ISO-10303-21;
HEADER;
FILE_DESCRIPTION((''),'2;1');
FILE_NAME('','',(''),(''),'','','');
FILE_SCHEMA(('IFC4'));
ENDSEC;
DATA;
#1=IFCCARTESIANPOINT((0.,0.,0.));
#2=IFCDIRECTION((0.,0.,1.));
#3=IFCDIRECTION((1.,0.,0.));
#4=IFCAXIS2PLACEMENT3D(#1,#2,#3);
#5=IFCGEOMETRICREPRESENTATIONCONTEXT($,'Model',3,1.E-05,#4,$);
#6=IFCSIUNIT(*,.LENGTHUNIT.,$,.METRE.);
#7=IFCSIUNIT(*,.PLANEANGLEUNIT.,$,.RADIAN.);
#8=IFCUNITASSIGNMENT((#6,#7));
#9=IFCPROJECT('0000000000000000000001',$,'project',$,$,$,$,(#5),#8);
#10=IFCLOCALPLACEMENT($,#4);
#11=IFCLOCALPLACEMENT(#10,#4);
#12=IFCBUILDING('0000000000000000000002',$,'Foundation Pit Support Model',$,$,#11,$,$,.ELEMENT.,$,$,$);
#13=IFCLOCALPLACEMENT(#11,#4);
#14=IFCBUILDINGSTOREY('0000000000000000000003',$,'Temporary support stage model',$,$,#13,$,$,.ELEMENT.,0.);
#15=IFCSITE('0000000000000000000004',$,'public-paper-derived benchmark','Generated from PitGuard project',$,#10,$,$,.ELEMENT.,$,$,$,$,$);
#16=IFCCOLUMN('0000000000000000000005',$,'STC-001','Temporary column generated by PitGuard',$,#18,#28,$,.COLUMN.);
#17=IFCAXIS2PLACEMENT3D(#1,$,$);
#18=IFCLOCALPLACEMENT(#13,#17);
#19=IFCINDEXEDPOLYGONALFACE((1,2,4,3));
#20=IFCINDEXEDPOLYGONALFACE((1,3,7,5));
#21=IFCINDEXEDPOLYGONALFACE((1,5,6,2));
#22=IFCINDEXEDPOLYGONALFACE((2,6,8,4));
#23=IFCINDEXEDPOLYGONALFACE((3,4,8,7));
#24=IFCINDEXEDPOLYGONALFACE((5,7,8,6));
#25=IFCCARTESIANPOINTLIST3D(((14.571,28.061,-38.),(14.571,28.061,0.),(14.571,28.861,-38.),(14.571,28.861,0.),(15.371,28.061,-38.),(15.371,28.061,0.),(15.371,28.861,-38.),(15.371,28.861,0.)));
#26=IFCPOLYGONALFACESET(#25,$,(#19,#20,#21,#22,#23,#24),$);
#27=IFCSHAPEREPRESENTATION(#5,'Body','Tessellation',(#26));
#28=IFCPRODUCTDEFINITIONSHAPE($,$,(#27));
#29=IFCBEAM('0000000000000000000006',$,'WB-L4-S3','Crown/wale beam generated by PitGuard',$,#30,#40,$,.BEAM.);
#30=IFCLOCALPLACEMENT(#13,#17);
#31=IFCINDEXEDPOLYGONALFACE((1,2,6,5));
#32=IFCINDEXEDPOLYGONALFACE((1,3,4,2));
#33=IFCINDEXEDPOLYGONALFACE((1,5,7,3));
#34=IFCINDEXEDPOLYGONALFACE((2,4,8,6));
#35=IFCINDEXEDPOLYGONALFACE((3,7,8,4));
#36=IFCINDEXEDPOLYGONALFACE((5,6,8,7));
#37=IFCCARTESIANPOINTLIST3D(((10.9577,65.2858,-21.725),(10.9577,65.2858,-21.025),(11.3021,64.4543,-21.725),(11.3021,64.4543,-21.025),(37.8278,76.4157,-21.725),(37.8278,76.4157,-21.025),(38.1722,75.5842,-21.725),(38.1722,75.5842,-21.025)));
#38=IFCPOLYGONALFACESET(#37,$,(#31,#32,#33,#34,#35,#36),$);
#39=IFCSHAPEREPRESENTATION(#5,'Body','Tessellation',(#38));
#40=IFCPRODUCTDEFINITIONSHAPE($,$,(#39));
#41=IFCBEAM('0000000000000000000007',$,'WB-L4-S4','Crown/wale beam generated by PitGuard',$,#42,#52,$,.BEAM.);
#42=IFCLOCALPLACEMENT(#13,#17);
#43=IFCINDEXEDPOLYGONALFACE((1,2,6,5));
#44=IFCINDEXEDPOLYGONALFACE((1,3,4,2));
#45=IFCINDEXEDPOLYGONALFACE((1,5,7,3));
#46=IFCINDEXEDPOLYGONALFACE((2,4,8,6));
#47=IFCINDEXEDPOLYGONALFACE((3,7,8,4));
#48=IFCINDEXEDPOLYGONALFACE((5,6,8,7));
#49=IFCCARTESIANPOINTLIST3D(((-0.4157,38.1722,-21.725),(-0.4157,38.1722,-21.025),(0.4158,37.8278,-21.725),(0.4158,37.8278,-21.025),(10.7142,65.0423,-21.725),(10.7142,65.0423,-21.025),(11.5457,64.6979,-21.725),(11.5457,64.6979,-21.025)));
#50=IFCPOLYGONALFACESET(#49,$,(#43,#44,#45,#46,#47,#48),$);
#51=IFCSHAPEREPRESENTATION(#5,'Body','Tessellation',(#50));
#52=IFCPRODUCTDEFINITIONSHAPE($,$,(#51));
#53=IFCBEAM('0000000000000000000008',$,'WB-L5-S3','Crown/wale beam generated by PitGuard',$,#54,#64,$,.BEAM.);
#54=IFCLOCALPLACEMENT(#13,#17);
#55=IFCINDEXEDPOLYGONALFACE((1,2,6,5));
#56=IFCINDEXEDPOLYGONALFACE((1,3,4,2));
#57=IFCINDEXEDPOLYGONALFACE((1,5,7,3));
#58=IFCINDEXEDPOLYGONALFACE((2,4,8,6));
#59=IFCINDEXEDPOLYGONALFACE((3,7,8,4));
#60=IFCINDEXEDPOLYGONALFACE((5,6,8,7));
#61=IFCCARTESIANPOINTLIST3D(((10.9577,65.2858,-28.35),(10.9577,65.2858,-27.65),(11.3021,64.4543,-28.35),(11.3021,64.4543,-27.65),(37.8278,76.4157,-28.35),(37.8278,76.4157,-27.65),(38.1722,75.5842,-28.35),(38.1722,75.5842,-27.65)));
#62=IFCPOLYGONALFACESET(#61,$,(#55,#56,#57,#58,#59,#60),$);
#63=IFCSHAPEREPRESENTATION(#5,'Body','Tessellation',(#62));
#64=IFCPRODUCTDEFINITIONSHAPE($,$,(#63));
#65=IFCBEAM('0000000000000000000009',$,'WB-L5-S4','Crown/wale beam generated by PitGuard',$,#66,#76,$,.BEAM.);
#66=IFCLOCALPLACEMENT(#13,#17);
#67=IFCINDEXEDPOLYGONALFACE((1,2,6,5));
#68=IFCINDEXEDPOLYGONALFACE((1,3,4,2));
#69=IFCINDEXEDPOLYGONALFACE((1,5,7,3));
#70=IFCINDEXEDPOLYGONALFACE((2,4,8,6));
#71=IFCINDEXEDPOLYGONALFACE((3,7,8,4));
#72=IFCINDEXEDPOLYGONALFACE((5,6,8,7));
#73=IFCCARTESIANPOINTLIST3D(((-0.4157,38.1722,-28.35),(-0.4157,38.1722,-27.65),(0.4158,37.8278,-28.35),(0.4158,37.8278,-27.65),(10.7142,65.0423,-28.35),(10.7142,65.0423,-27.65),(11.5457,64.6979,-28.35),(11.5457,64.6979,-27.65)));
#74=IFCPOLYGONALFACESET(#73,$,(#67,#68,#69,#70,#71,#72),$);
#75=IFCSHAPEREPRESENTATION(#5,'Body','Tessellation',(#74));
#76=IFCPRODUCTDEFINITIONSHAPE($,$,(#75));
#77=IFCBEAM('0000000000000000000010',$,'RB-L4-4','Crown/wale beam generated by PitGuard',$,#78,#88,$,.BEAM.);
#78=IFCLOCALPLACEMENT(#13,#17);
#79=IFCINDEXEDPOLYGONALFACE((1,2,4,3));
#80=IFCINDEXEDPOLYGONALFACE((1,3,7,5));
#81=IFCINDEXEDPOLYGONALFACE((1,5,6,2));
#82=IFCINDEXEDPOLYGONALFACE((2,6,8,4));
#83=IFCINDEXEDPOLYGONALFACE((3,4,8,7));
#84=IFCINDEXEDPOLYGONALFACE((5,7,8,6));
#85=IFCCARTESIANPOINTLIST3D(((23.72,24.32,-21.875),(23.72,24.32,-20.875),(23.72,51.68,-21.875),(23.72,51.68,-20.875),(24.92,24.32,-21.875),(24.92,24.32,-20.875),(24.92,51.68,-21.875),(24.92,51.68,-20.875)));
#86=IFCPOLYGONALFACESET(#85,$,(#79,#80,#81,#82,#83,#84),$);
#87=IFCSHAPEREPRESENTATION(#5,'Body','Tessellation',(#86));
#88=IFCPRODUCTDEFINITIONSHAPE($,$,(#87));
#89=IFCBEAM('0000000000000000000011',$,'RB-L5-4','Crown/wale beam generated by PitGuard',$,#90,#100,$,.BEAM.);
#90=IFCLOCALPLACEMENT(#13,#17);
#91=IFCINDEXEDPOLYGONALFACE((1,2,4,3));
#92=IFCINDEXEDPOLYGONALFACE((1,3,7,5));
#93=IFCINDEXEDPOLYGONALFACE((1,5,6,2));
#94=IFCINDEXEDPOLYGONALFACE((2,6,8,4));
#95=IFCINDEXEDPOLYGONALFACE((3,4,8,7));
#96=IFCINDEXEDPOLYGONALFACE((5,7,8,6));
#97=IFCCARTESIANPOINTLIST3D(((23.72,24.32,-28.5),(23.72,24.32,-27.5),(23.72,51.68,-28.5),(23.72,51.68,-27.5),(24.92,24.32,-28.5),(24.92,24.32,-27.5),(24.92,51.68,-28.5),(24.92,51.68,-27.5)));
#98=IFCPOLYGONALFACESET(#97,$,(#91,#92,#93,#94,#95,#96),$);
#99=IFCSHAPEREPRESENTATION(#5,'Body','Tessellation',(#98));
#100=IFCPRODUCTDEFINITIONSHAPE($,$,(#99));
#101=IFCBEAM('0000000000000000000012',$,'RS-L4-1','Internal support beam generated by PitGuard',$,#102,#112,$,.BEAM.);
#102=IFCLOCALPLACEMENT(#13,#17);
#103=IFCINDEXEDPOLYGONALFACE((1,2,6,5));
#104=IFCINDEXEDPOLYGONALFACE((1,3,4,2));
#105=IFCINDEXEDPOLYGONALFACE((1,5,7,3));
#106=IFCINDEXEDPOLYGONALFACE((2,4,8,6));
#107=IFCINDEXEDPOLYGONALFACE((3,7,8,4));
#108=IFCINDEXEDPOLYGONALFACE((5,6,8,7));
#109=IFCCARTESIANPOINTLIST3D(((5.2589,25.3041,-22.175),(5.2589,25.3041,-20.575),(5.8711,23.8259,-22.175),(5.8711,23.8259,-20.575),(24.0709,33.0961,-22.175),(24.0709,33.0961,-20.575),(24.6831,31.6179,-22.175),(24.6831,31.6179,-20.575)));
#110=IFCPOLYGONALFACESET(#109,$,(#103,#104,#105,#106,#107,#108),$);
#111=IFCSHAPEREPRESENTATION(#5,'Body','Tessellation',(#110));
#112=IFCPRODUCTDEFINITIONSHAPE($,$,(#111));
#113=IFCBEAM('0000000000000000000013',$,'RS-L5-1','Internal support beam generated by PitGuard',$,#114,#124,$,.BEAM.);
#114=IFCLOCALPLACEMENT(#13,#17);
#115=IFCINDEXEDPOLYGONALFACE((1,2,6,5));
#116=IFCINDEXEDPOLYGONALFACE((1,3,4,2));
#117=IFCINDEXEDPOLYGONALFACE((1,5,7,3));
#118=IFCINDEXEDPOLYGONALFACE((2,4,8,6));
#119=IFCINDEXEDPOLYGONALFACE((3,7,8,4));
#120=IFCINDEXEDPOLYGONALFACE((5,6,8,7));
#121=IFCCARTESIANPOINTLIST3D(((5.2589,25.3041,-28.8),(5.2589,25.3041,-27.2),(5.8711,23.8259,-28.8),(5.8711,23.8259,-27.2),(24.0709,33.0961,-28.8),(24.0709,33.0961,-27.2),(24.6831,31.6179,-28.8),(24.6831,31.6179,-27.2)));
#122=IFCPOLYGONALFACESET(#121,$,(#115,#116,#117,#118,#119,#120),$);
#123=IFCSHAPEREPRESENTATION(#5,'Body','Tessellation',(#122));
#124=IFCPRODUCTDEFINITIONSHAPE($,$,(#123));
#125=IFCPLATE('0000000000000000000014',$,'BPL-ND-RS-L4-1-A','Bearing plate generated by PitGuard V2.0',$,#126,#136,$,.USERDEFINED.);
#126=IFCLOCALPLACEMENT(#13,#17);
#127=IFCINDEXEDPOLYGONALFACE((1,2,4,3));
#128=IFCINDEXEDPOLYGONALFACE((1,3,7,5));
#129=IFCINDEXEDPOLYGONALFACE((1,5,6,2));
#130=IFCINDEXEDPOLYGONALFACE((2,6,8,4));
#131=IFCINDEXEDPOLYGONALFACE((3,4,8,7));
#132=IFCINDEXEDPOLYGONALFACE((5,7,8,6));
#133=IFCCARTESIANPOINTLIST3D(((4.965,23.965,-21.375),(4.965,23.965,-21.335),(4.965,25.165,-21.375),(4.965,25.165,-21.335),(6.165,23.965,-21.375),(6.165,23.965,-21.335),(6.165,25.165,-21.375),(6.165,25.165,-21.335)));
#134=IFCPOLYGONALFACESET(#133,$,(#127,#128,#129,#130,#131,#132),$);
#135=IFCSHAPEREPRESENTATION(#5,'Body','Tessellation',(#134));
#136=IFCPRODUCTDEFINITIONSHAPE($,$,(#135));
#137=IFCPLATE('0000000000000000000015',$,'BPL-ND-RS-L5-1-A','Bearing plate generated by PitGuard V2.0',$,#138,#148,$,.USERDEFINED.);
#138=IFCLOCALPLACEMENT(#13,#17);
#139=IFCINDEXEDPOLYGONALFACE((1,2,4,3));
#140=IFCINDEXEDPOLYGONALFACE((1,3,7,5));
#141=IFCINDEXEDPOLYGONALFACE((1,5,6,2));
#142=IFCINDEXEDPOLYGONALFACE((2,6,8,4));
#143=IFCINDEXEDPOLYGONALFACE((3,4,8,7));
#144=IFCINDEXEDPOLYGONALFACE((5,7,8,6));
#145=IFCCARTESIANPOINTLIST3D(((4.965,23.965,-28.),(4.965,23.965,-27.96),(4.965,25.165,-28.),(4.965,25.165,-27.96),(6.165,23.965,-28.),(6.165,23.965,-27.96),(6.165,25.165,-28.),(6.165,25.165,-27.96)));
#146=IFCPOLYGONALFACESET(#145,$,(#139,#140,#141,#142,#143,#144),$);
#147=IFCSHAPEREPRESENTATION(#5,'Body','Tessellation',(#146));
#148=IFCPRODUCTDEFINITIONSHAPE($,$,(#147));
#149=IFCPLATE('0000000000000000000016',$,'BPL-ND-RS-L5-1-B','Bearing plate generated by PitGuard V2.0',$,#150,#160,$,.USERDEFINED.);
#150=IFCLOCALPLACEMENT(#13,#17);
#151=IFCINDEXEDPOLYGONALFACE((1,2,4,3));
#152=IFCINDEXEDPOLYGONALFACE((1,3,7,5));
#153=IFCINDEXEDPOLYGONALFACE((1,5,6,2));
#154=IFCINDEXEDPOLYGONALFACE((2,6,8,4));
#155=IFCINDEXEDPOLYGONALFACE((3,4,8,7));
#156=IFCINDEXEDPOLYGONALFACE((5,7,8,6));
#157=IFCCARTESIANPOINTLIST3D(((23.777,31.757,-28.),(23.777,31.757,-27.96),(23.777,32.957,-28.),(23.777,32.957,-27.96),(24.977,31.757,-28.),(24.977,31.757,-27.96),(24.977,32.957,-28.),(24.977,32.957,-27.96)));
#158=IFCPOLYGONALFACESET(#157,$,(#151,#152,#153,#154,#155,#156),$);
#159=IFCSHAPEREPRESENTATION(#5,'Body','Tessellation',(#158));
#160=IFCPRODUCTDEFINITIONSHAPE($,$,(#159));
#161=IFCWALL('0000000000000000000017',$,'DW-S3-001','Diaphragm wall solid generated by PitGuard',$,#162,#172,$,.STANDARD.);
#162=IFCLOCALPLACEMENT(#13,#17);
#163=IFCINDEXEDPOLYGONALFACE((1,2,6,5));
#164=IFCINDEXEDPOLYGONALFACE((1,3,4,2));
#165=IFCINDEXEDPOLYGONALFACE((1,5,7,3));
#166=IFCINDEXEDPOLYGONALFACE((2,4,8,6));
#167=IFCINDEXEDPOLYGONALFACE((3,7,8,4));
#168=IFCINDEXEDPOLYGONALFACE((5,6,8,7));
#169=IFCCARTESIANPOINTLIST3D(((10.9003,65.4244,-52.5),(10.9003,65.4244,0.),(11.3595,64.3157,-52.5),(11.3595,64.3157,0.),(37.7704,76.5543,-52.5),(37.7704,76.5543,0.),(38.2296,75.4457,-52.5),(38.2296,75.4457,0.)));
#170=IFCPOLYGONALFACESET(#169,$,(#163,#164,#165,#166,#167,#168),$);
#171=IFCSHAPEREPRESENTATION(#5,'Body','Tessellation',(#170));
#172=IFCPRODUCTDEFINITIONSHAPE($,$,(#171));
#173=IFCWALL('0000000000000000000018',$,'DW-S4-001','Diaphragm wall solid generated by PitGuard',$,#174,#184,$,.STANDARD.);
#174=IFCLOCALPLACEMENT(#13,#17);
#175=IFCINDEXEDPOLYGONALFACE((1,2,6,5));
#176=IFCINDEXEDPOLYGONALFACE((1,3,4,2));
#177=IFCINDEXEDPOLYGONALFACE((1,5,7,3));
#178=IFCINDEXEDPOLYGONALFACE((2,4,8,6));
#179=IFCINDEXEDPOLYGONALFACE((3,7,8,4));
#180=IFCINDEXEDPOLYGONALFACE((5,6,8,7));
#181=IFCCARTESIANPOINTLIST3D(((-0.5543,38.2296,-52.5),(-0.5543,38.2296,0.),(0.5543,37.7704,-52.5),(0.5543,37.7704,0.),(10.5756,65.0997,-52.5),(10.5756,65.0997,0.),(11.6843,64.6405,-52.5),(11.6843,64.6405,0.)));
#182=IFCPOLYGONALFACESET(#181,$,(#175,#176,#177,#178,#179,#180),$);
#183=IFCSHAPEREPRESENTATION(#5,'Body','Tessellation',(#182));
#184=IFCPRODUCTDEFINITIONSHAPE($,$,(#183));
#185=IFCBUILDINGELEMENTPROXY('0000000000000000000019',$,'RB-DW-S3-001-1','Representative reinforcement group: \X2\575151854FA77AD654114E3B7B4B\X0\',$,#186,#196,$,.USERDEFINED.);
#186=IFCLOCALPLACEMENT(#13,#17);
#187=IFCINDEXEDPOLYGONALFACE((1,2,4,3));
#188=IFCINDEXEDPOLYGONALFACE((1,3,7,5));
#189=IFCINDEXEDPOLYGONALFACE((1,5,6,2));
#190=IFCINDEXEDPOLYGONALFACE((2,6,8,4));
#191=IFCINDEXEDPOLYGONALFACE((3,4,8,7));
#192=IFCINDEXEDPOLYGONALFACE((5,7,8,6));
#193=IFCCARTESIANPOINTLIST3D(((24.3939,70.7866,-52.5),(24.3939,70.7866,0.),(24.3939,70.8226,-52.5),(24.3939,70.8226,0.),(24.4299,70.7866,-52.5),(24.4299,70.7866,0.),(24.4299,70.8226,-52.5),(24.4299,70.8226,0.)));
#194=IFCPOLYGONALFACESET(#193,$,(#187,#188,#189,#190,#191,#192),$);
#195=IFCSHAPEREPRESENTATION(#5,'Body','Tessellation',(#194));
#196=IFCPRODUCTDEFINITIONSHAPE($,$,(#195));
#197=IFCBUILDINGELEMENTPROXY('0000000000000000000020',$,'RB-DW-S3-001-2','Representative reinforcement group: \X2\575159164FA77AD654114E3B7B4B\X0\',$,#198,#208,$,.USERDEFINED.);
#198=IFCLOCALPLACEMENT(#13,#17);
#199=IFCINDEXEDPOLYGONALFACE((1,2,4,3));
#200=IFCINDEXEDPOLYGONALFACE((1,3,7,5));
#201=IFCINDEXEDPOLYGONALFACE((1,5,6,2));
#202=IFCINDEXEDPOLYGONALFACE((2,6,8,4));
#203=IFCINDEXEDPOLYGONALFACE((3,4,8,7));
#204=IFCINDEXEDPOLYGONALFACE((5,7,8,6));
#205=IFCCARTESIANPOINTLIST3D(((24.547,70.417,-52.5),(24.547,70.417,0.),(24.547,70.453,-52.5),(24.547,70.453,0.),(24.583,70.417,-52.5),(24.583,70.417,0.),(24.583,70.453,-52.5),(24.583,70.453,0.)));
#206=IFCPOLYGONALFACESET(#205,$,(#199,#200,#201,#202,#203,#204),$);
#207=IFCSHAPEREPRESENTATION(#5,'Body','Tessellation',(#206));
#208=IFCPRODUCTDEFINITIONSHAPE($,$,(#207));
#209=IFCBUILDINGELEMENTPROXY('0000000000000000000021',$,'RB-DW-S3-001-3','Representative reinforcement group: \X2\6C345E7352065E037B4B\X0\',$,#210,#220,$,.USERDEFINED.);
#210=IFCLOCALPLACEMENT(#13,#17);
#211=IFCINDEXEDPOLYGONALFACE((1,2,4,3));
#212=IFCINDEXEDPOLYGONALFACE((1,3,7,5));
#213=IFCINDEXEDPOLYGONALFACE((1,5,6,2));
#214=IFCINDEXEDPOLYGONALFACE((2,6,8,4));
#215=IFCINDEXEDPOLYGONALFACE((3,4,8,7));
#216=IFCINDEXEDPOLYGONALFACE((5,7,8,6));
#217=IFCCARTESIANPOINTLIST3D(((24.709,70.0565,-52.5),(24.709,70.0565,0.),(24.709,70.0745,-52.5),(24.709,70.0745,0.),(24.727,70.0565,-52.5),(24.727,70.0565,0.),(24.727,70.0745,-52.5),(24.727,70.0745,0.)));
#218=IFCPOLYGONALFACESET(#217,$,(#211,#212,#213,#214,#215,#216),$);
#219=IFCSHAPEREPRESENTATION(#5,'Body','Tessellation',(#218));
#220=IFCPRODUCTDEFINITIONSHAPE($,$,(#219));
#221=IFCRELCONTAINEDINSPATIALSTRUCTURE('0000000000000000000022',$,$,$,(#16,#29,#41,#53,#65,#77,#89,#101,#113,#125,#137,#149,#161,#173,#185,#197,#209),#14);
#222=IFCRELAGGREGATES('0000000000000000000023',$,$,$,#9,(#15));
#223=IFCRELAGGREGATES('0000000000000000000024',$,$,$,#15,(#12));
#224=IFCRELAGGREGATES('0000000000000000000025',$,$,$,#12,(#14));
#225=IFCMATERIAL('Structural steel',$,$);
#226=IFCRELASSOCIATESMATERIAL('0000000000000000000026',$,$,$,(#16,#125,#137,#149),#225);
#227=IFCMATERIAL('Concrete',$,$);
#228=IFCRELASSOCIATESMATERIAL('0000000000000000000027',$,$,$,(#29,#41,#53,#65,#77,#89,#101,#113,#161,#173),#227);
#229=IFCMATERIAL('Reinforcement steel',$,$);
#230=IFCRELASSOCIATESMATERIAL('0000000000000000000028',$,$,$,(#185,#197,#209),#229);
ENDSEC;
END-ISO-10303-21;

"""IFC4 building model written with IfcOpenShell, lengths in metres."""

from ifc_helpers import new_model, si_unit, frame, origin_with_axes, origin_2d, place, context, project, spatial, rectangle, extrude, material, element, save


model = new_model("IFC4")

# Units and contexts
model_context = context("Model", 3, precision=1e-05, world=origin_with_axes())
ifc_project = project(units=[si_unit("LENGTHUNIT", "METRE"), si_unit("PLANEANGLEUNIT", "RADIAN")], contexts=[model_context])

# Site, building, storey
site_placement = place(None, origin_with_axes())
site = spatial("IfcSite", under=ifc_project, at=site_placement, Name="public-paper-derived benchmark", Description="Generated from PitGuard project", CompositionType="ELEMENT")
building_placement = place(site_placement, origin_with_axes())
building = spatial("IfcBuilding", under=site, at=building_placement, Name="Foundation Pit Support Model", CompositionType="ELEMENT")
storey_placement = place(building_placement, origin_with_axes())
storey = spatial("IfcBuildingStorey", under=building, at=storey_placement, Name="Temporary support stage model", CompositionType="ELEMENT", Elevation=0.0)

# Column
ifc_material_1 = material(Name="Structural steel")
column_placement = place(storey_placement, frame((14.971, 28.461, -38.0), z_axis=(0.0, 0.0, 1.0), x_axis=(1.0, 0.0, 0.0)))
element("IfcColumn", 1, at=column_placement, inside=storey, material=ifc_material_1, Name="STC-001", Description="Temporary column generated by PitGuard", PredefinedType="COLUMN", context=model_context, shape_type="SweptSolid", body=[
    extrude(rectangle(XDim=0.8, YDim=0.8, at=origin_2d()), origin_with_axes(), (0.0, 0.0, 1.0), 38.0),
])

# Beams
ifc_material_2 = material(Name="Concrete")
for number, where, z_axis, x_axis, name in (
    (2, (24.565, 70.435, -21.725), (0.0, 0.0, 1.0), (-0.92388, -0.382683, 0.0), "WB-L4-S3"),
    (3, (5.565, 51.435, -21.725), (0.0, 0.0, 1.0), (-0.382683, -0.92388, 0.0), "WB-L4-S4"),
    (4, (24.565, 70.435, -28.35), (0.0, 0.0, 1.0), (-0.92388, -0.382683, 0.0), "WB-L5-S3"),
    (5, (5.565, 51.435, -28.35), (0.0, 0.0, 1.0), (-0.382683, -0.92388, 0.0), "WB-L5-S4"),
):
    element("IfcBeam", number, at=place(storey_placement, frame(where, z_axis=z_axis, x_axis=x_axis)), inside=storey, material=ifc_material_2, Name=name, Description="Crown/wale beam generated by PitGuard", PredefinedType="BEAM", context=model_context, shape_type="SweptSolid", body=[
        extrude(rectangle(XDim=29.0839, YDim=0.9, at=origin_2d()), origin_with_axes(), (0.0, 0.0, 1.0), 0.7),
    ])
for number, where, z_axis, x_axis, name in (
    (6, (24.32, 38.0, -21.875), (0.0, 0.0, 1.0), (0.0, -1.0, 0.0), "RB-L4-4"),
    (7, (24.32, 38.0, -28.5), (0.0, 0.0, 1.0), (0.0, -1.0, 0.0), "RB-L5-4"),
):
    element("IfcBeam", number, at=place(storey_placement, frame(where, z_axis=z_axis, x_axis=x_axis)), inside=storey, material=ifc_material_2, Name=name, Description="Crown/wale beam generated by PitGuard", PredefinedType="BEAM", context=model_context, shape_type="SweptSolid", body=[
        extrude(rectangle(XDim=27.36, YDim=1.2, at=origin_2d()), origin_with_axes(), (0.0, 0.0, 1.0), 1.0),
    ])
for number, where, z_axis, x_axis, name in (
    (8, (14.971, 28.461, -22.175), (0.0, 0.0, 1.0), (0.923883, 0.382676, 0.0), "RS-L4-1"),
    (9, (14.971, 28.461, -28.8), (0.0, 0.0, 1.0), (0.923883, 0.382676, 0.0), "RS-L5-1"),
):
    element("IfcBeam", number, at=place(storey_placement, frame(where, z_axis=z_axis, x_axis=x_axis)), inside=storey, material=ifc_material_2, Name=name, Description="Internal support beam generated by PitGuard", PredefinedType="BEAM", context=model_context, shape_type="SweptSolid", body=[
        extrude(rectangle(XDim=20.3619, YDim=1.6, at=origin_2d()), origin_with_axes(), (0.0, 0.0, 1.0), 1.6),
    ])

# Plates
for number, where, z_axis, x_axis, name in (
    (10, (5.565, 24.565, -21.375), (0.0, 0.0, 1.0), (1.0, 0.0, 0.0), "BPL-ND-RS-L4-1-A"),
    (11, (5.565, 24.565, -28.0), (0.0, 0.0, 1.0), (1.0, 0.0, 0.0), "BPL-ND-RS-L5-1-A"),
    (12, (24.377, 32.357, -28.0), (0.0, 0.0, 1.0), (1.0, 0.0, 0.0), "BPL-ND-RS-L5-1-B"),
):
    element("IfcPlate", number, at=place(storey_placement, frame(where, z_axis=z_axis, x_axis=x_axis)), inside=storey, material=ifc_material_1, Name=name, Description="Bearing plate generated by PitGuard V2.0", PredefinedType="USERDEFINED", context=model_context, shape_type="SweptSolid", body=[
        extrude(rectangle(XDim=1.2, YDim=1.2, at=origin_2d()), origin_with_axes(), (0.0, 0.0, 1.0), 0.04),
    ])

# Walls
for number, where, z_axis, x_axis, name in (
    (13, (24.565, 70.435, -52.5), (0.0, 0.0, 1.0), (-0.92388, -0.382683, 0.0), "DW-S3-001"),
    (14, (5.565, 51.435, -52.5), (0.0, 0.0, 1.0), (-0.382683, -0.92388, 0.0), "DW-S4-001"),
):
    element("IfcWall", number, at=place(storey_placement, frame(where, z_axis=z_axis, x_axis=x_axis)), inside=storey, material=ifc_material_2, Name=name, Description="Diaphragm wall solid generated by PitGuard", PredefinedType="STANDARD", context=model_context, shape_type="SweptSolid", body=[
        extrude(rectangle(XDim=29.0839, YDim=1.2, at=origin_2d()), origin_with_axes(), (0.0, 0.0, 1.0), 52.5),
    ])

# Building element proxies
ifc_material_3 = material(Name="Reinforcement steel")
for number, where, z_axis, x_axis, name, description in (
    (15, (24.4119, 70.8046, -52.5), (0.0, 0.0, 1.0), (1.0, 0.0, 0.0), "RB-DW-S3-001-1", "Representative reinforcement group: 坑内侧竖向主筋"),
    (16, (24.565, 70.435, -52.5), (0.0, 0.0, 1.0), (1.0, 0.0, 0.0), "RB-DW-S3-001-2", "Representative reinforcement group: 坑外侧竖向主筋"),
):
    element("IfcBuildingElementProxy", number, at=place(storey_placement, frame(where, z_axis=z_axis, x_axis=x_axis)), inside=storey, material=ifc_material_3, Name=name, Description=description, PredefinedType="USERDEFINED", context=model_context, shape_type="SweptSolid", body=[
        extrude(rectangle(XDim=0.036, YDim=0.036, at=origin_2d()), origin_with_axes(), (0.0, 0.0, 1.0), 52.5),
    ])
proxy_1_placement = place(storey_placement, frame((24.718, 70.0655, -52.5), z_axis=(0.0, 0.0, 1.0), x_axis=(1.0, 0.0, 0.0)))
element("IfcBuildingElementProxy", 17, at=proxy_1_placement, inside=storey, material=ifc_material_3, Name="RB-DW-S3-001-3", Description="Representative reinforcement group: 水平分布筋", PredefinedType="USERDEFINED", context=model_context, shape_type="SweptSolid", body=[
    extrude(rectangle(XDim=0.018, YDim=0.018, at=origin_2d()), origin_with_axes(), (0.0, 0.0, 1.0), 52.5),
])

save(model, "model.ifc")
